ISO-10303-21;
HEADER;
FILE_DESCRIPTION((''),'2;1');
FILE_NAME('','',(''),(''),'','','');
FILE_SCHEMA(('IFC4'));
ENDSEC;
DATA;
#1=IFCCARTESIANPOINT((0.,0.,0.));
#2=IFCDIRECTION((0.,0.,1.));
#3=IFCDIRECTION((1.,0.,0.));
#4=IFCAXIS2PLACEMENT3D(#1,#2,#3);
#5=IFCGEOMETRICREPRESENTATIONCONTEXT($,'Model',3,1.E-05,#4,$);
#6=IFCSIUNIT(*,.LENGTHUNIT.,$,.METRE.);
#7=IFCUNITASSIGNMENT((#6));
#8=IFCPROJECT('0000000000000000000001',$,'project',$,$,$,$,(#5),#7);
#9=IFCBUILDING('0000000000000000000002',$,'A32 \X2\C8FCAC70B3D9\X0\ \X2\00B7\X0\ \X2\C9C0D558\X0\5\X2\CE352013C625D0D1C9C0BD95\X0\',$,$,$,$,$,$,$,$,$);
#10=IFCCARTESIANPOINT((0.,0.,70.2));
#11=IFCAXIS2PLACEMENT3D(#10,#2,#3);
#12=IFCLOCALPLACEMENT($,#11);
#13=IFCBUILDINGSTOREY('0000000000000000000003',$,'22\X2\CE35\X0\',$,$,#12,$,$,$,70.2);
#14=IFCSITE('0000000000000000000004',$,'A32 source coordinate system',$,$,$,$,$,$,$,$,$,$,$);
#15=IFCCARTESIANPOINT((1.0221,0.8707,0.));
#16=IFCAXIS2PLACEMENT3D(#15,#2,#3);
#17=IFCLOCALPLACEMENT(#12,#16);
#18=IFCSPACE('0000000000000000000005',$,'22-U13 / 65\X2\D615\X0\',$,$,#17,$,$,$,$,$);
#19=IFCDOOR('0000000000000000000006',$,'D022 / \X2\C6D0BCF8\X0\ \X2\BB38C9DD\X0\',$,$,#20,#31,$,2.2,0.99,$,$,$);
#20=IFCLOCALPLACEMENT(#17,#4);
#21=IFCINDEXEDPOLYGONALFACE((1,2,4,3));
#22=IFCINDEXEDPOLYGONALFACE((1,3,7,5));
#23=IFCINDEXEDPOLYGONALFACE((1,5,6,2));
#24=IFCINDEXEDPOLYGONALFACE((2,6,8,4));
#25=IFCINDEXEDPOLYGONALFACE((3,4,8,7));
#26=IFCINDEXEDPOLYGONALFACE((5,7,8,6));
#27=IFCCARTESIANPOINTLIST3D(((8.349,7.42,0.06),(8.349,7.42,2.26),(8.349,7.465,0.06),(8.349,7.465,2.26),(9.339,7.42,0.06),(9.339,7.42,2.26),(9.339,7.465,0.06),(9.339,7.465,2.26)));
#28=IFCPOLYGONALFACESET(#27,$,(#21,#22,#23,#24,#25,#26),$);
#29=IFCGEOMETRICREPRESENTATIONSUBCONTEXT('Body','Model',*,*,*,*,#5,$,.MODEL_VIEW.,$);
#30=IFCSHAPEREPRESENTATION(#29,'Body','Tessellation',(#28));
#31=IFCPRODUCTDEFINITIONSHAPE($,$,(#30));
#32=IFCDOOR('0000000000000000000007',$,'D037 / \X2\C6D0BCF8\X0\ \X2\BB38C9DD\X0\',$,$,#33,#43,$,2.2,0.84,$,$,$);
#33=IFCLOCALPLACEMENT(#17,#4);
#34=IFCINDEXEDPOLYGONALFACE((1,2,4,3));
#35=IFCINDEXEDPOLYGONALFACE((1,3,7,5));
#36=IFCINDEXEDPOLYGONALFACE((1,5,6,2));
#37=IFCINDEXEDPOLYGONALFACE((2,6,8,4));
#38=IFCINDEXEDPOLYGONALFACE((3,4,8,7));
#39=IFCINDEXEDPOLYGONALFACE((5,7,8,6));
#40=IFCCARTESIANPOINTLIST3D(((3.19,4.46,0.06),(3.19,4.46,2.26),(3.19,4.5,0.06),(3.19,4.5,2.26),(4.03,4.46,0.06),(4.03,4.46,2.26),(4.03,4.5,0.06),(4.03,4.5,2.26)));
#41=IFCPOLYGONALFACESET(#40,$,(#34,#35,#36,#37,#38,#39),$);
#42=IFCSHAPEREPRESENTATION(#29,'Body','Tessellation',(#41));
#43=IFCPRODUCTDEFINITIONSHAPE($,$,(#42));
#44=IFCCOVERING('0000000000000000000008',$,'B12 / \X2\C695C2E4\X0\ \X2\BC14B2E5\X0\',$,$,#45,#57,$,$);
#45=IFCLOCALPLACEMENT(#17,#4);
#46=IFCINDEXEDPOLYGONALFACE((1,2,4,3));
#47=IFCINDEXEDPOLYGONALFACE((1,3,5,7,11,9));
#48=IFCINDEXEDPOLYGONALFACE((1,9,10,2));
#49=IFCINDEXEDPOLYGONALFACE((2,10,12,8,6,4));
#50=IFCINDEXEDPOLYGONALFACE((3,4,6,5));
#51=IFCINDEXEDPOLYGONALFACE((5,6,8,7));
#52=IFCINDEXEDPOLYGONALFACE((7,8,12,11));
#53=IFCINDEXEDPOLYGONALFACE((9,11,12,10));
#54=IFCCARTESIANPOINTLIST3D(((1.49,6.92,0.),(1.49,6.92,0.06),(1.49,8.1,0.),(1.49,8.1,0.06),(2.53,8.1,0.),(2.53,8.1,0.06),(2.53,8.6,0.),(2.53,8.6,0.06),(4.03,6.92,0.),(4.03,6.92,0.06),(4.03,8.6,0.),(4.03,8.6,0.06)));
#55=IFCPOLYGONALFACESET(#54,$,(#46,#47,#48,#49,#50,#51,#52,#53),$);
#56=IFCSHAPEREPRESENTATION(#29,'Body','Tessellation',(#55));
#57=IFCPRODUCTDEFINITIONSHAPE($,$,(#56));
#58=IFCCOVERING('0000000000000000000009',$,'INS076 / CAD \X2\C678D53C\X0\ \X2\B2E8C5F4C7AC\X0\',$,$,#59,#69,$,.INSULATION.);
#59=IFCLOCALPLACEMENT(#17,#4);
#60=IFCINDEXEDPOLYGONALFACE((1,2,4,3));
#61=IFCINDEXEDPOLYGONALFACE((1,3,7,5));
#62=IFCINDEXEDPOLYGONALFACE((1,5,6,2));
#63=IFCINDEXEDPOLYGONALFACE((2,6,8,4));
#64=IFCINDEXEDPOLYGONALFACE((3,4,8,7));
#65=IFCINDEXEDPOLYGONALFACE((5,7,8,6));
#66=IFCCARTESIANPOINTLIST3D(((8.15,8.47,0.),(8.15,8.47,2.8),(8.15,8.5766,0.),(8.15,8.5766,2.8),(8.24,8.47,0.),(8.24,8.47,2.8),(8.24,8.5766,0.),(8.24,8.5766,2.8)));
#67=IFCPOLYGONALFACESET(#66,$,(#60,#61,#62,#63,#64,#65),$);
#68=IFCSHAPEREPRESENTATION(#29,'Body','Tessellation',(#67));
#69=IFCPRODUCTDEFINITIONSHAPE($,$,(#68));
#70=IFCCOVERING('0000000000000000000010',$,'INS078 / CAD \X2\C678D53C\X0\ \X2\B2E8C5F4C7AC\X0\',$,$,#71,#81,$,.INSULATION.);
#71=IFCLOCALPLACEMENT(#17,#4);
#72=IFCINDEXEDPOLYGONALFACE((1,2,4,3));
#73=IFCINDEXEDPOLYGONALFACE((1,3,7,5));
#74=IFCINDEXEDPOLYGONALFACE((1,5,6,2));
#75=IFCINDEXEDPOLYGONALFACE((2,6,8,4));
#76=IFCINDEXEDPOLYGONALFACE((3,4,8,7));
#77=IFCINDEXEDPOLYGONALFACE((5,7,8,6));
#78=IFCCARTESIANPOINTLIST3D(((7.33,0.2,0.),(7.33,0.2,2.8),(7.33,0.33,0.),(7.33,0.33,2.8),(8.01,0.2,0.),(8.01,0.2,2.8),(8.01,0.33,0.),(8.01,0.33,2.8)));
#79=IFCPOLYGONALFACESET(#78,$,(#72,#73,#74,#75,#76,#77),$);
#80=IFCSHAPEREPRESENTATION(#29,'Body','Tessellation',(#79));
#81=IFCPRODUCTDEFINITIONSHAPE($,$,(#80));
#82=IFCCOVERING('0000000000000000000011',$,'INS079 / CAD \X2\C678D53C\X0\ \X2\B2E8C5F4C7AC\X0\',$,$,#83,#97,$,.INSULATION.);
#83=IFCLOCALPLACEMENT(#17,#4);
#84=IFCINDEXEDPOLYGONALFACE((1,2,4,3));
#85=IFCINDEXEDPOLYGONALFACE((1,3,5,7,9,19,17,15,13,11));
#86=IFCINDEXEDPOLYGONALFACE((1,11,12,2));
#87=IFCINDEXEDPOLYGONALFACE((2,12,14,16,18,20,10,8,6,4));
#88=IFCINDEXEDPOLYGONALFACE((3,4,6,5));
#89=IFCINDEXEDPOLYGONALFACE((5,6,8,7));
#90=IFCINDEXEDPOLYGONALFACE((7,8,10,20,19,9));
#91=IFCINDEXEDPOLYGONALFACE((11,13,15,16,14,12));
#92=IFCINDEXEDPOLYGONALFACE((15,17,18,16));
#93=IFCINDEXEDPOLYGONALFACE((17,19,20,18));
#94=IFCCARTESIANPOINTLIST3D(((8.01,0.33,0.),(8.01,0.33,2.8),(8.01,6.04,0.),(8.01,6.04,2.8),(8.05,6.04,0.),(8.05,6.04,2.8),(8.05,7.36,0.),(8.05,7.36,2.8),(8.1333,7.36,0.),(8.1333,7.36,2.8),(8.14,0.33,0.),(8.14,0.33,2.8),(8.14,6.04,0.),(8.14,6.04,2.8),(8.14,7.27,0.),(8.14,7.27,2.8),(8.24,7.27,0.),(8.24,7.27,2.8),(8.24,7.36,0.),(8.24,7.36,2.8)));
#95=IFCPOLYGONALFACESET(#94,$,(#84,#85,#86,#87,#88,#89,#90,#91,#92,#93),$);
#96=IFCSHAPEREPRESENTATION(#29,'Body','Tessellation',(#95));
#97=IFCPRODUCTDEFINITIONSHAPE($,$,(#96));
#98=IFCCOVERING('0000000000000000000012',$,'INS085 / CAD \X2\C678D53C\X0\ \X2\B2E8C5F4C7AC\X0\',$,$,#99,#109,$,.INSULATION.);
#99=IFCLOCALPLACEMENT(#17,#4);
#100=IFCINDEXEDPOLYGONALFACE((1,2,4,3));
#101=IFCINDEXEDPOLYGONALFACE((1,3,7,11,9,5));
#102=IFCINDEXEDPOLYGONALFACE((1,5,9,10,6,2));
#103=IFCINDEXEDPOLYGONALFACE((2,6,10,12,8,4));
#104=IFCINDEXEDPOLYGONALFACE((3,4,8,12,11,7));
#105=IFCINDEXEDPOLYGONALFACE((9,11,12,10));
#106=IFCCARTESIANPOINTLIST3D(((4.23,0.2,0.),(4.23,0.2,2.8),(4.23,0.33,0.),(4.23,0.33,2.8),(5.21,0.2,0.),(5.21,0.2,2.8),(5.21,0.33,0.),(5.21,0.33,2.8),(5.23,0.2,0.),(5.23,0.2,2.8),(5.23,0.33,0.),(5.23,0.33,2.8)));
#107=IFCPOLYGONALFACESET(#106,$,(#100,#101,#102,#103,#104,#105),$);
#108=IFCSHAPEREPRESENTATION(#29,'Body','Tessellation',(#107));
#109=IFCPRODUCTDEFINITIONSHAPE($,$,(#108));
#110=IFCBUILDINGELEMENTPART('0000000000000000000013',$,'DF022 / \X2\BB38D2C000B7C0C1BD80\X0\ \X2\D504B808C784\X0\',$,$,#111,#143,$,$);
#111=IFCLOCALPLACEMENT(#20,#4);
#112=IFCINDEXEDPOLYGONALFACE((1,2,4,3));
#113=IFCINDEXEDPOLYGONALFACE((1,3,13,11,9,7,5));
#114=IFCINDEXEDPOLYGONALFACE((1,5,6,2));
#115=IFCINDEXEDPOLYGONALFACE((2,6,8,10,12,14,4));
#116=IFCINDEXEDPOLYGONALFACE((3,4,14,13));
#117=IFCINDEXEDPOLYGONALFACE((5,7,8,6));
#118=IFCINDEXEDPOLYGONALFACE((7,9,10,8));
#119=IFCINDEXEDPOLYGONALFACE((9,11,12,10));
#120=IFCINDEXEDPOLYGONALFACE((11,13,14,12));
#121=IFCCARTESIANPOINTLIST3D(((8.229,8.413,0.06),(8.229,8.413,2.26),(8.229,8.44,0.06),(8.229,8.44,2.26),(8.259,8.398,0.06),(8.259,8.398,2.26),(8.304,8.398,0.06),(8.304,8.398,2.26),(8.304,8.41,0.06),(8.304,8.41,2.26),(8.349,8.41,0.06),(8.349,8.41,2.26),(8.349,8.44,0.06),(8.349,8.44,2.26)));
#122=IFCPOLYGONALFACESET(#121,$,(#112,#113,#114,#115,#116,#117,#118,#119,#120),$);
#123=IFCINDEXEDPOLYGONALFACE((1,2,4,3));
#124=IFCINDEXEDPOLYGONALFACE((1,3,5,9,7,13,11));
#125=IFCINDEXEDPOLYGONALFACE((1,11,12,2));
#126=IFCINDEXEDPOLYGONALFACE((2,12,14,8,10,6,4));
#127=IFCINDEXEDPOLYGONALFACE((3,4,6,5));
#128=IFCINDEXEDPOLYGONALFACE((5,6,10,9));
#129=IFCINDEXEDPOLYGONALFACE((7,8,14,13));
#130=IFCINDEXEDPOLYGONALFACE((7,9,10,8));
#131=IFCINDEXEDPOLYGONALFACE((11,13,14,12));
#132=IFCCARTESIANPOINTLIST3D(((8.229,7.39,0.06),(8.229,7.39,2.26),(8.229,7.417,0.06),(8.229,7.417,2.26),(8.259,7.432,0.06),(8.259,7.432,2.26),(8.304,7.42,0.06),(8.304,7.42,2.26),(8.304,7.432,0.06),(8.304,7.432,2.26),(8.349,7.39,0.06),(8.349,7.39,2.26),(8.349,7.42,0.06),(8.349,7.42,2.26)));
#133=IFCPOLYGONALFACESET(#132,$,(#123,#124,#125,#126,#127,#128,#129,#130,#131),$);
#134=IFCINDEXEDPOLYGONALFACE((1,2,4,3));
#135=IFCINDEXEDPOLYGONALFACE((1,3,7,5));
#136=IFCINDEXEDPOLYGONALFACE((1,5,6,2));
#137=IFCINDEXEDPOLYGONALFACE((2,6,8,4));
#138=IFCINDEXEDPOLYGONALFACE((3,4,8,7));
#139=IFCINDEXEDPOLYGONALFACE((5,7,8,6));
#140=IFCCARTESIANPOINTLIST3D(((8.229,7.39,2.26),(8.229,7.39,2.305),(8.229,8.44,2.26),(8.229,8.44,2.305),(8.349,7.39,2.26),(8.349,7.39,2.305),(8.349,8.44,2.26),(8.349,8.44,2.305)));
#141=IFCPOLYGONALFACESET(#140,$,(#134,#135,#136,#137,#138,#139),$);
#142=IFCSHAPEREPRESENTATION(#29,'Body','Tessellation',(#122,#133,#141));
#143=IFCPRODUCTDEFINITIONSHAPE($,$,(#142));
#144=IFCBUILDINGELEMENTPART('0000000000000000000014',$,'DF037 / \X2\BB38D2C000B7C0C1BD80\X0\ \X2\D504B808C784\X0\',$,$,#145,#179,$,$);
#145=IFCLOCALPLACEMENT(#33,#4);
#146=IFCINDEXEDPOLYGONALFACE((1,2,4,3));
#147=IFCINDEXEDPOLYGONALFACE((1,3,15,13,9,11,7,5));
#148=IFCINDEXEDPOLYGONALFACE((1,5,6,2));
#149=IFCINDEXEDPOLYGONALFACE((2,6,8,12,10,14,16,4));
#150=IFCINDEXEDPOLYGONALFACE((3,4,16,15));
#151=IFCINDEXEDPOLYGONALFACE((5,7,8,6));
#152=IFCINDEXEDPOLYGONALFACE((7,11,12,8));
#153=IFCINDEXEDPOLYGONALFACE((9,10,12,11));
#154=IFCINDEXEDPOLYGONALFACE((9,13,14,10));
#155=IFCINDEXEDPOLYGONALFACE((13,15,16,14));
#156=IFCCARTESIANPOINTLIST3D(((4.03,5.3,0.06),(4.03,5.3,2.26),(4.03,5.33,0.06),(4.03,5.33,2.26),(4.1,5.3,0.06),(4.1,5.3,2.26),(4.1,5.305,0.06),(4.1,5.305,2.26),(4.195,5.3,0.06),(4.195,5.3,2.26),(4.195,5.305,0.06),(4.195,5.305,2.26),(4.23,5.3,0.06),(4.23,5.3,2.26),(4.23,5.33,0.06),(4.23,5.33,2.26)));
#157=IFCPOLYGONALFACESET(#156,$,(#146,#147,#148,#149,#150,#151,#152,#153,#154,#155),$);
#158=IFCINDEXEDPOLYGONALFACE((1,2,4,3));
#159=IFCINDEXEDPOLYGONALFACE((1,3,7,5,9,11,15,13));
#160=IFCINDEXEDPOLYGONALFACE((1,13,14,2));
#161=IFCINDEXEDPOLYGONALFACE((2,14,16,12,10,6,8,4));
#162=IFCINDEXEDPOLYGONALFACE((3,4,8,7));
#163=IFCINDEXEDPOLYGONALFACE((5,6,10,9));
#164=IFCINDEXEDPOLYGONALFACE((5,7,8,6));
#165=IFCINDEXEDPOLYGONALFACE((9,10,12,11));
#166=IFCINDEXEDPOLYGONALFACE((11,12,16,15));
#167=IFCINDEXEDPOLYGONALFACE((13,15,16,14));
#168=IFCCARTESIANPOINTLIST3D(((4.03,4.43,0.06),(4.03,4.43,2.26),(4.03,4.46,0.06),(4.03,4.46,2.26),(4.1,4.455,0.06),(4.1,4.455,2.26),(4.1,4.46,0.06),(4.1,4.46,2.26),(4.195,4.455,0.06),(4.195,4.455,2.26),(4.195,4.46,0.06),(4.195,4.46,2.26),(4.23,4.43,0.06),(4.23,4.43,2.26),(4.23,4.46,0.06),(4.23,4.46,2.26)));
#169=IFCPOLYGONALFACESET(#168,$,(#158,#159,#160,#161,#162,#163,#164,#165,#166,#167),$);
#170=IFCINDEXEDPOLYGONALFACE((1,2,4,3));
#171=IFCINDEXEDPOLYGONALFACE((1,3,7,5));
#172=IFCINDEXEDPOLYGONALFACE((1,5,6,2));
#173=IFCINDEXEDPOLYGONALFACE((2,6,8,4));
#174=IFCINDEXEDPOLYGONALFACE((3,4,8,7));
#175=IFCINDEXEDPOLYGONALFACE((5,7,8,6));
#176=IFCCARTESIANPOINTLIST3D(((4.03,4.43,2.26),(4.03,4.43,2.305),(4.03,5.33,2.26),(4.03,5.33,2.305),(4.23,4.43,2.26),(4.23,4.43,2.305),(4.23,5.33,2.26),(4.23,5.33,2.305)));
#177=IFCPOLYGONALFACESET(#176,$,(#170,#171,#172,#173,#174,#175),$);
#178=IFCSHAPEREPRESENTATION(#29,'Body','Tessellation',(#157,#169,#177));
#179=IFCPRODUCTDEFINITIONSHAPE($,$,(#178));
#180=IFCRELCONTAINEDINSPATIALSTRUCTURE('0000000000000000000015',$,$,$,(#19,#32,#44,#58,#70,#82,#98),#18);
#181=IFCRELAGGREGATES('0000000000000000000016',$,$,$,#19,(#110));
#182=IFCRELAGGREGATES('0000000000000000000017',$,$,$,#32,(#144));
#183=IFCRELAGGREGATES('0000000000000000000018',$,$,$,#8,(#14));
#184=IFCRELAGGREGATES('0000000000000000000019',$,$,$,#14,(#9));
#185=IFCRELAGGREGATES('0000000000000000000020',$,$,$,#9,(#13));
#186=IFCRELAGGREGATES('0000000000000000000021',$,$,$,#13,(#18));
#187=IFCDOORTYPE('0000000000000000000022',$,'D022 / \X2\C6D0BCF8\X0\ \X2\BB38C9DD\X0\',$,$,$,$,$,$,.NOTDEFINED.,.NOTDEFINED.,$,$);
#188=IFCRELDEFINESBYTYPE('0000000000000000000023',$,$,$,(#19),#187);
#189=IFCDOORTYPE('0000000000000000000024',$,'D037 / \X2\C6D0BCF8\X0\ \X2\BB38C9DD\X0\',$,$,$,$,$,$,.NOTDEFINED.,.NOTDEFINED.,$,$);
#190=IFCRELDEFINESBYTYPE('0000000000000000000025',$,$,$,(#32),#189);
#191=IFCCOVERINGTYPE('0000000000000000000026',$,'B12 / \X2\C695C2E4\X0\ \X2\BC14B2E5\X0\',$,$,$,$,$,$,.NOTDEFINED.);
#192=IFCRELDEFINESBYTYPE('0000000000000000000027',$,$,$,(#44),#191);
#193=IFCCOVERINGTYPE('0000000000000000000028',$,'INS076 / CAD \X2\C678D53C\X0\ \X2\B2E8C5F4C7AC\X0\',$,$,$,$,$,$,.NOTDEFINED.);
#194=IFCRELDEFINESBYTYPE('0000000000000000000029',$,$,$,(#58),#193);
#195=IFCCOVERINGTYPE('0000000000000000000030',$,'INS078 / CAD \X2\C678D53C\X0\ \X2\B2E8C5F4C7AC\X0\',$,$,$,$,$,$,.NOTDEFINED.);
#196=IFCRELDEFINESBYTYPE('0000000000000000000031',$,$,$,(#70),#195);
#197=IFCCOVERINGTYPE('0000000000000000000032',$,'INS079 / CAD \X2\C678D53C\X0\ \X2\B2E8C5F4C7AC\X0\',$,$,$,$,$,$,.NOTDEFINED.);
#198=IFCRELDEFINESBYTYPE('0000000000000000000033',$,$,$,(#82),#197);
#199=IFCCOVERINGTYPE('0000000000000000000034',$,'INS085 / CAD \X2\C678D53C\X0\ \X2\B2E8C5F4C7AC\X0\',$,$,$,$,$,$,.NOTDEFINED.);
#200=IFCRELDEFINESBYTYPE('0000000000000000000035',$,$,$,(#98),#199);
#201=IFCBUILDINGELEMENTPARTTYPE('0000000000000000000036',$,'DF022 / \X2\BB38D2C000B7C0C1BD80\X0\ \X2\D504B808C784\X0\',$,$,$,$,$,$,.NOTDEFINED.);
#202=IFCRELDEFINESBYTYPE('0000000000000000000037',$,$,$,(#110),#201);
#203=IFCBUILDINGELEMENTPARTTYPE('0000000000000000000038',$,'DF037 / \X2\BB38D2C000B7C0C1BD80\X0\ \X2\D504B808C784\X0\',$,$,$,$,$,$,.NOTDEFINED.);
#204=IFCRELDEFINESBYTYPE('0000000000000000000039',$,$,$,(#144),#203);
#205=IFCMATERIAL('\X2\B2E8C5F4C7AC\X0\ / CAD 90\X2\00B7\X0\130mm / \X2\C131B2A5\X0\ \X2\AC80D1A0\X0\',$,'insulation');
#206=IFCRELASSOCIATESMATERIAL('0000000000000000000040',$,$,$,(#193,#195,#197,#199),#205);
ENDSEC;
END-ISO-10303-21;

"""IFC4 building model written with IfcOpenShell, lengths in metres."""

from ifc_helpers import new_model, si_unit, frame, origin, origin_with_axes, place, context, subcontext, project, spatial, polyline, outline, extrude, source, transform, mapped, material, type_object, type_shapes, element, aggregate, save


model = new_model("IFC4")

# Units and contexts
model_context = context("Model", 3, precision=1e-05, world=origin_with_axes())
body_context = subcontext(model_context, "Body", "Model", "MODEL_VIEW")
ifc_project = project(units=[si_unit("LENGTHUNIT", "METRE")], contexts=[model_context])

# Site, building, storey
site = spatial("IfcSite", under=ifc_project, Name="A32 source coordinate system")
building = spatial("IfcBuilding", under=site, Name="A32 주거동 · 지하5층–옥탑지붕")
storey_placement = place(None, frame((0.0, 0.0, 70.2), z_axis=(0.0, 0.0, 1.0), x_axis=(1.0, 0.0, 0.0)))
storey = spatial("IfcBuildingStorey", under=building, at=storey_placement, Name="22층", Elevation=70.2)

# Shared definitions
space_placement = place(storey_placement, frame((1.0221, 0.8707, 0.0), z_axis=(0.0, 0.0, 1.0), x_axis=(1.0, 0.0, 0.0)))
space = spatial("IfcSpace", under=storey, at=space_placement, Name="22-U13 / 65형")

# Doors
door_type_1 = type_object("IfcDoorType", Name="D022 / 원본 문짝", OperationType="NOTDEFINED", PredefinedType="NOTDEFINED")
shared_shape_1 = source(origin(), body_context, "Body", "SweptSolid", [
    extrude(outline(polyline([(9.339, 7.465), (9.339, 7.42), (8.349, 7.42), (8.349, 7.465), (9.339, 7.465)])), frame((0.0, 0.0, 0.06)), (0.0, 0.0, 1.0), 2.2),
])
type_shapes(door_type_1, [shared_shape_1])
door_1_placement = place(space_placement, origin_with_axes())
door_1 = element("IfcDoor", 1, at=door_1_placement, inside=space, type_object=door_type_1, Name="D022 / 원본 문짝", OverallHeight=2.2, OverallWidth=0.99, context=body_context, shape_type="MappedRepresentation", body=[
    mapped(shared_shape_1, transform((0.0, 0.0, 0.0), scale=1.0)),
])
door_type_2 = type_object("IfcDoorType", Name="D037 / 원본 문짝", OperationType="NOTDEFINED", PredefinedType="NOTDEFINED")
shared_shape_2 = source(origin(), body_context, "Body", "SweptSolid", [
    extrude(outline(polyline([(4.03, 4.46), (3.19, 4.46), (3.19, 4.5), (4.03, 4.5), (4.03, 4.46)])), frame((0.0, 0.0, 0.06)), (0.0, 0.0, 1.0), 2.2),
])
type_shapes(door_type_2, [shared_shape_2])
door_2_placement = place(space_placement, origin_with_axes())
door_2 = element("IfcDoor", 2, at=door_2_placement, inside=space, type_object=door_type_2, Name="D037 / 원본 문짝", OverallHeight=2.2, OverallWidth=0.84, context=body_context, shape_type="MappedRepresentation", body=[
    mapped(shared_shape_2, transform((0.0, 0.0, 0.0), scale=1.0)),
])

# Coverings
covering_type_1 = type_object("IfcCoveringType", Name="B12 / 욕실 바닥", PredefinedType="NOTDEFINED")
shared_shape_3 = source(origin(), body_context, "Body", "SweptSolid", [
    extrude(outline(polyline([(2.53, 8.6), (4.03, 8.6), (4.03, 6.92), (1.49, 6.92), (1.49, 8.1), (2.53, 8.1), (2.53, 8.6)])), origin(), (0.0, 0.0, 1.0), 0.06),
])
type_shapes(covering_type_1, [shared_shape_3])
covering_1_placement = place(space_placement, origin_with_axes())
element("IfcCovering", 3, at=covering_1_placement, inside=space, type_object=covering_type_1, Name="B12 / 욕실 바닥", context=body_context, shape_type="MappedRepresentation", body=[
    mapped(shared_shape_3, transform((0.0, 0.0, 0.0), scale=1.0)),
])
ifc_material = material(Name="단열재 / CAD 90·130mm / 성능 검토", Category="insulation")
covering_type_2 = type_object("IfcCoveringType", Name="INS076 / CAD 외피 단열재", PredefinedType="NOTDEFINED", material=ifc_material)
shared_shape_4 = source(origin(), body_context, "Body", "SweptSolid", [
    extrude(outline(polyline([(8.24, 8.5766), (8.24, 8.47), (8.15, 8.47), (8.15, 8.5766), (8.24, 8.5766)])), origin(), (0.0, 0.0, 1.0), 2.8),
])
type_shapes(covering_type_2, [shared_shape_4])
covering_2_placement = place(space_placement, origin_with_axes())
element("IfcCovering", 4, at=covering_2_placement, inside=space, type_object=covering_type_2, Name="INS076 / CAD 외피 단열재", PredefinedType="INSULATION", context=body_context, shape_type="MappedRepresentation", body=[
    mapped(shared_shape_4, transform((0.0, 0.0, 0.0), scale=1.0)),
])
covering_type_3 = type_object("IfcCoveringType", Name="INS078 / CAD 외피 단열재", PredefinedType="NOTDEFINED", material=ifc_material)
shared_shape_5 = source(origin(), body_context, "Body", "SweptSolid", [
    extrude(outline(polyline([(8.01, 0.2), (7.33, 0.2), (7.33, 0.33), (8.01, 0.33), (8.01, 0.2)])), origin(), (0.0, 0.0, 1.0), 2.8),
])
type_shapes(covering_type_3, [shared_shape_5])
covering_3_placement = place(space_placement, origin_with_axes())
element("IfcCovering", 5, at=covering_3_placement, inside=space, type_object=covering_type_3, Name="INS078 / CAD 외피 단열재", PredefinedType="INSULATION", context=body_context, shape_type="MappedRepresentation", body=[
    mapped(shared_shape_5, transform((0.0, 0.0, 0.0), scale=1.0)),
])
covering_type_4 = type_object("IfcCoveringType", Name="INS079 / CAD 외피 단열재", PredefinedType="NOTDEFINED", material=ifc_material)
shared_shape_6 = source(origin(), body_context, "Body", "SweptSolid", [
    extrude(outline(polyline([(8.24, 7.27), (8.14, 7.27), (8.14, 6.04), (8.14, 0.33), (8.01, 0.33), (8.01, 6.04), (8.05, 6.04), (8.05, 7.36), (8.1333, 7.36), (8.24, 7.36), (8.24, 7.27)])), origin(), (0.0, 0.0, 1.0), 2.8),
])
type_shapes(covering_type_4, [shared_shape_6])
covering_4_placement = place(space_placement, origin_with_axes())
element("IfcCovering", 6, at=covering_4_placement, inside=space, type_object=covering_type_4, Name="INS079 / CAD 외피 단열재", PredefinedType="INSULATION", context=body_context, shape_type="MappedRepresentation", body=[
    mapped(shared_shape_6, transform((0.0, 0.0, 0.0), scale=1.0)),
])
covering_type_5 = type_object("IfcCoveringType", Name="INS085 / CAD 외피 단열재", PredefinedType="NOTDEFINED", material=ifc_material)
shared_shape_7 = source(origin(), body_context, "Body", "SweptSolid", [
    extrude(outline(polyline([(4.23, 0.2), (4.23, 0.33), (5.21, 0.33), (5.23, 0.33), (5.23, 0.2), (5.21, 0.2), (4.23, 0.2)])), origin(), (0.0, 0.0, 1.0), 2.8),
])
type_shapes(covering_type_5, [shared_shape_7])
covering_5_placement = place(space_placement, origin_with_axes())
element("IfcCovering", 7, at=covering_5_placement, inside=space, type_object=covering_type_5, Name="INS085 / CAD 외피 단열재", PredefinedType="INSULATION", context=body_context, shape_type="MappedRepresentation", body=[
    mapped(shared_shape_7, transform((0.0, 0.0, 0.0), scale=1.0)),
])

# Building element parts
building_element_part_type_1 = type_object("IfcBuildingElementPartType", Name="DF022 / 문틀·상부 프레임", PredefinedType="NOTDEFINED")
shared_shape_8 = source(origin(), body_context, "Body", "SweptSolid", [
    extrude(outline(polyline([(8.349, 8.41), (8.304, 8.41), (8.304, 8.398), (8.259, 8.398), (8.229, 8.413), (8.229, 8.44), (8.349, 8.44), (8.349, 8.41)])), frame((0.0, 0.0, 0.06)), (0.0, 0.0, 1.0), 2.2),
    extrude(outline(polyline([(8.229, 7.39), (8.229, 7.417), (8.259, 7.432), (8.304, 7.432), (8.304, 7.42), (8.349, 7.42), (8.349, 7.39), (8.229, 7.39)])), frame((0.0, 0.0, 0.06)), (0.0, 0.0, 1.0), 2.2),
    extrude(outline(polyline([(8.229, 7.39), (8.229, 8.44), (8.349, 8.44), (8.349, 7.39), (8.229, 7.39)])), frame((0.0, 0.0, 2.26)), (0.0, 0.0, 1.0), 0.045),
])
type_shapes(building_element_part_type_1, [shared_shape_8])
building_element_part_1_placement = place(door_1_placement, origin_with_axes())
building_element_part_1 = element("IfcBuildingElementPart", 8, at=building_element_part_1_placement, type_object=building_element_part_type_1, Name="DF022 / 문틀·상부 프레임", context=body_context, shape_type="MappedRepresentation", body=[
    mapped(shared_shape_8, transform((0.0, 0.0, 0.0), scale=1.0)),
])
aggregate(door_1, [building_element_part_1])
building_element_part_type_2 = type_object("IfcBuildingElementPartType", Name="DF037 / 문틀·상부 프레임", PredefinedType="NOTDEFINED")
shared_shape_9 = source(origin(), body_context, "Body", "SweptSolid", [
    extrude(outline(polyline([(4.23, 5.33), (4.23, 5.3), (4.195, 5.3), (4.195, 5.305), (4.1, 5.305), (4.1, 5.3), (4.03, 5.3), (4.03, 5.33), (4.23, 5.33)])), frame((0.0, 0.0, 0.06)), (0.0, 0.0, 1.0), 2.2),
    extrude(outline(polyline([(4.03, 4.46), (4.1, 4.46), (4.1, 4.455), (4.195, 4.455), (4.195, 4.46), (4.23, 4.46), (4.23, 4.43), (4.03, 4.43), (4.03, 4.46)])), frame((0.0, 0.0, 0.06)), (0.0, 0.0, 1.0), 2.2),
    extrude(outline(polyline([(4.03, 4.43), (4.03, 5.33), (4.23, 5.33), (4.23, 4.43), (4.03, 4.43)])), frame((0.0, 0.0, 2.26)), (0.0, 0.0, 1.0), 0.045),
])
type_shapes(building_element_part_type_2, [shared_shape_9])
building_element_part_2_placement = place(door_2_placement, origin_with_axes())
building_element_part_2 = element("IfcBuildingElementPart", 9, at=building_element_part_2_placement, type_object=building_element_part_type_2, Name="DF037 / 문틀·상부 프레임", context=body_context, shape_type="MappedRepresentation", body=[
    mapped(shared_shape_9, transform((0.0, 0.0, 0.0), scale=1.0)),
])
aggregate(door_2, [building_element_part_2])

save(model, "model.ifc")
